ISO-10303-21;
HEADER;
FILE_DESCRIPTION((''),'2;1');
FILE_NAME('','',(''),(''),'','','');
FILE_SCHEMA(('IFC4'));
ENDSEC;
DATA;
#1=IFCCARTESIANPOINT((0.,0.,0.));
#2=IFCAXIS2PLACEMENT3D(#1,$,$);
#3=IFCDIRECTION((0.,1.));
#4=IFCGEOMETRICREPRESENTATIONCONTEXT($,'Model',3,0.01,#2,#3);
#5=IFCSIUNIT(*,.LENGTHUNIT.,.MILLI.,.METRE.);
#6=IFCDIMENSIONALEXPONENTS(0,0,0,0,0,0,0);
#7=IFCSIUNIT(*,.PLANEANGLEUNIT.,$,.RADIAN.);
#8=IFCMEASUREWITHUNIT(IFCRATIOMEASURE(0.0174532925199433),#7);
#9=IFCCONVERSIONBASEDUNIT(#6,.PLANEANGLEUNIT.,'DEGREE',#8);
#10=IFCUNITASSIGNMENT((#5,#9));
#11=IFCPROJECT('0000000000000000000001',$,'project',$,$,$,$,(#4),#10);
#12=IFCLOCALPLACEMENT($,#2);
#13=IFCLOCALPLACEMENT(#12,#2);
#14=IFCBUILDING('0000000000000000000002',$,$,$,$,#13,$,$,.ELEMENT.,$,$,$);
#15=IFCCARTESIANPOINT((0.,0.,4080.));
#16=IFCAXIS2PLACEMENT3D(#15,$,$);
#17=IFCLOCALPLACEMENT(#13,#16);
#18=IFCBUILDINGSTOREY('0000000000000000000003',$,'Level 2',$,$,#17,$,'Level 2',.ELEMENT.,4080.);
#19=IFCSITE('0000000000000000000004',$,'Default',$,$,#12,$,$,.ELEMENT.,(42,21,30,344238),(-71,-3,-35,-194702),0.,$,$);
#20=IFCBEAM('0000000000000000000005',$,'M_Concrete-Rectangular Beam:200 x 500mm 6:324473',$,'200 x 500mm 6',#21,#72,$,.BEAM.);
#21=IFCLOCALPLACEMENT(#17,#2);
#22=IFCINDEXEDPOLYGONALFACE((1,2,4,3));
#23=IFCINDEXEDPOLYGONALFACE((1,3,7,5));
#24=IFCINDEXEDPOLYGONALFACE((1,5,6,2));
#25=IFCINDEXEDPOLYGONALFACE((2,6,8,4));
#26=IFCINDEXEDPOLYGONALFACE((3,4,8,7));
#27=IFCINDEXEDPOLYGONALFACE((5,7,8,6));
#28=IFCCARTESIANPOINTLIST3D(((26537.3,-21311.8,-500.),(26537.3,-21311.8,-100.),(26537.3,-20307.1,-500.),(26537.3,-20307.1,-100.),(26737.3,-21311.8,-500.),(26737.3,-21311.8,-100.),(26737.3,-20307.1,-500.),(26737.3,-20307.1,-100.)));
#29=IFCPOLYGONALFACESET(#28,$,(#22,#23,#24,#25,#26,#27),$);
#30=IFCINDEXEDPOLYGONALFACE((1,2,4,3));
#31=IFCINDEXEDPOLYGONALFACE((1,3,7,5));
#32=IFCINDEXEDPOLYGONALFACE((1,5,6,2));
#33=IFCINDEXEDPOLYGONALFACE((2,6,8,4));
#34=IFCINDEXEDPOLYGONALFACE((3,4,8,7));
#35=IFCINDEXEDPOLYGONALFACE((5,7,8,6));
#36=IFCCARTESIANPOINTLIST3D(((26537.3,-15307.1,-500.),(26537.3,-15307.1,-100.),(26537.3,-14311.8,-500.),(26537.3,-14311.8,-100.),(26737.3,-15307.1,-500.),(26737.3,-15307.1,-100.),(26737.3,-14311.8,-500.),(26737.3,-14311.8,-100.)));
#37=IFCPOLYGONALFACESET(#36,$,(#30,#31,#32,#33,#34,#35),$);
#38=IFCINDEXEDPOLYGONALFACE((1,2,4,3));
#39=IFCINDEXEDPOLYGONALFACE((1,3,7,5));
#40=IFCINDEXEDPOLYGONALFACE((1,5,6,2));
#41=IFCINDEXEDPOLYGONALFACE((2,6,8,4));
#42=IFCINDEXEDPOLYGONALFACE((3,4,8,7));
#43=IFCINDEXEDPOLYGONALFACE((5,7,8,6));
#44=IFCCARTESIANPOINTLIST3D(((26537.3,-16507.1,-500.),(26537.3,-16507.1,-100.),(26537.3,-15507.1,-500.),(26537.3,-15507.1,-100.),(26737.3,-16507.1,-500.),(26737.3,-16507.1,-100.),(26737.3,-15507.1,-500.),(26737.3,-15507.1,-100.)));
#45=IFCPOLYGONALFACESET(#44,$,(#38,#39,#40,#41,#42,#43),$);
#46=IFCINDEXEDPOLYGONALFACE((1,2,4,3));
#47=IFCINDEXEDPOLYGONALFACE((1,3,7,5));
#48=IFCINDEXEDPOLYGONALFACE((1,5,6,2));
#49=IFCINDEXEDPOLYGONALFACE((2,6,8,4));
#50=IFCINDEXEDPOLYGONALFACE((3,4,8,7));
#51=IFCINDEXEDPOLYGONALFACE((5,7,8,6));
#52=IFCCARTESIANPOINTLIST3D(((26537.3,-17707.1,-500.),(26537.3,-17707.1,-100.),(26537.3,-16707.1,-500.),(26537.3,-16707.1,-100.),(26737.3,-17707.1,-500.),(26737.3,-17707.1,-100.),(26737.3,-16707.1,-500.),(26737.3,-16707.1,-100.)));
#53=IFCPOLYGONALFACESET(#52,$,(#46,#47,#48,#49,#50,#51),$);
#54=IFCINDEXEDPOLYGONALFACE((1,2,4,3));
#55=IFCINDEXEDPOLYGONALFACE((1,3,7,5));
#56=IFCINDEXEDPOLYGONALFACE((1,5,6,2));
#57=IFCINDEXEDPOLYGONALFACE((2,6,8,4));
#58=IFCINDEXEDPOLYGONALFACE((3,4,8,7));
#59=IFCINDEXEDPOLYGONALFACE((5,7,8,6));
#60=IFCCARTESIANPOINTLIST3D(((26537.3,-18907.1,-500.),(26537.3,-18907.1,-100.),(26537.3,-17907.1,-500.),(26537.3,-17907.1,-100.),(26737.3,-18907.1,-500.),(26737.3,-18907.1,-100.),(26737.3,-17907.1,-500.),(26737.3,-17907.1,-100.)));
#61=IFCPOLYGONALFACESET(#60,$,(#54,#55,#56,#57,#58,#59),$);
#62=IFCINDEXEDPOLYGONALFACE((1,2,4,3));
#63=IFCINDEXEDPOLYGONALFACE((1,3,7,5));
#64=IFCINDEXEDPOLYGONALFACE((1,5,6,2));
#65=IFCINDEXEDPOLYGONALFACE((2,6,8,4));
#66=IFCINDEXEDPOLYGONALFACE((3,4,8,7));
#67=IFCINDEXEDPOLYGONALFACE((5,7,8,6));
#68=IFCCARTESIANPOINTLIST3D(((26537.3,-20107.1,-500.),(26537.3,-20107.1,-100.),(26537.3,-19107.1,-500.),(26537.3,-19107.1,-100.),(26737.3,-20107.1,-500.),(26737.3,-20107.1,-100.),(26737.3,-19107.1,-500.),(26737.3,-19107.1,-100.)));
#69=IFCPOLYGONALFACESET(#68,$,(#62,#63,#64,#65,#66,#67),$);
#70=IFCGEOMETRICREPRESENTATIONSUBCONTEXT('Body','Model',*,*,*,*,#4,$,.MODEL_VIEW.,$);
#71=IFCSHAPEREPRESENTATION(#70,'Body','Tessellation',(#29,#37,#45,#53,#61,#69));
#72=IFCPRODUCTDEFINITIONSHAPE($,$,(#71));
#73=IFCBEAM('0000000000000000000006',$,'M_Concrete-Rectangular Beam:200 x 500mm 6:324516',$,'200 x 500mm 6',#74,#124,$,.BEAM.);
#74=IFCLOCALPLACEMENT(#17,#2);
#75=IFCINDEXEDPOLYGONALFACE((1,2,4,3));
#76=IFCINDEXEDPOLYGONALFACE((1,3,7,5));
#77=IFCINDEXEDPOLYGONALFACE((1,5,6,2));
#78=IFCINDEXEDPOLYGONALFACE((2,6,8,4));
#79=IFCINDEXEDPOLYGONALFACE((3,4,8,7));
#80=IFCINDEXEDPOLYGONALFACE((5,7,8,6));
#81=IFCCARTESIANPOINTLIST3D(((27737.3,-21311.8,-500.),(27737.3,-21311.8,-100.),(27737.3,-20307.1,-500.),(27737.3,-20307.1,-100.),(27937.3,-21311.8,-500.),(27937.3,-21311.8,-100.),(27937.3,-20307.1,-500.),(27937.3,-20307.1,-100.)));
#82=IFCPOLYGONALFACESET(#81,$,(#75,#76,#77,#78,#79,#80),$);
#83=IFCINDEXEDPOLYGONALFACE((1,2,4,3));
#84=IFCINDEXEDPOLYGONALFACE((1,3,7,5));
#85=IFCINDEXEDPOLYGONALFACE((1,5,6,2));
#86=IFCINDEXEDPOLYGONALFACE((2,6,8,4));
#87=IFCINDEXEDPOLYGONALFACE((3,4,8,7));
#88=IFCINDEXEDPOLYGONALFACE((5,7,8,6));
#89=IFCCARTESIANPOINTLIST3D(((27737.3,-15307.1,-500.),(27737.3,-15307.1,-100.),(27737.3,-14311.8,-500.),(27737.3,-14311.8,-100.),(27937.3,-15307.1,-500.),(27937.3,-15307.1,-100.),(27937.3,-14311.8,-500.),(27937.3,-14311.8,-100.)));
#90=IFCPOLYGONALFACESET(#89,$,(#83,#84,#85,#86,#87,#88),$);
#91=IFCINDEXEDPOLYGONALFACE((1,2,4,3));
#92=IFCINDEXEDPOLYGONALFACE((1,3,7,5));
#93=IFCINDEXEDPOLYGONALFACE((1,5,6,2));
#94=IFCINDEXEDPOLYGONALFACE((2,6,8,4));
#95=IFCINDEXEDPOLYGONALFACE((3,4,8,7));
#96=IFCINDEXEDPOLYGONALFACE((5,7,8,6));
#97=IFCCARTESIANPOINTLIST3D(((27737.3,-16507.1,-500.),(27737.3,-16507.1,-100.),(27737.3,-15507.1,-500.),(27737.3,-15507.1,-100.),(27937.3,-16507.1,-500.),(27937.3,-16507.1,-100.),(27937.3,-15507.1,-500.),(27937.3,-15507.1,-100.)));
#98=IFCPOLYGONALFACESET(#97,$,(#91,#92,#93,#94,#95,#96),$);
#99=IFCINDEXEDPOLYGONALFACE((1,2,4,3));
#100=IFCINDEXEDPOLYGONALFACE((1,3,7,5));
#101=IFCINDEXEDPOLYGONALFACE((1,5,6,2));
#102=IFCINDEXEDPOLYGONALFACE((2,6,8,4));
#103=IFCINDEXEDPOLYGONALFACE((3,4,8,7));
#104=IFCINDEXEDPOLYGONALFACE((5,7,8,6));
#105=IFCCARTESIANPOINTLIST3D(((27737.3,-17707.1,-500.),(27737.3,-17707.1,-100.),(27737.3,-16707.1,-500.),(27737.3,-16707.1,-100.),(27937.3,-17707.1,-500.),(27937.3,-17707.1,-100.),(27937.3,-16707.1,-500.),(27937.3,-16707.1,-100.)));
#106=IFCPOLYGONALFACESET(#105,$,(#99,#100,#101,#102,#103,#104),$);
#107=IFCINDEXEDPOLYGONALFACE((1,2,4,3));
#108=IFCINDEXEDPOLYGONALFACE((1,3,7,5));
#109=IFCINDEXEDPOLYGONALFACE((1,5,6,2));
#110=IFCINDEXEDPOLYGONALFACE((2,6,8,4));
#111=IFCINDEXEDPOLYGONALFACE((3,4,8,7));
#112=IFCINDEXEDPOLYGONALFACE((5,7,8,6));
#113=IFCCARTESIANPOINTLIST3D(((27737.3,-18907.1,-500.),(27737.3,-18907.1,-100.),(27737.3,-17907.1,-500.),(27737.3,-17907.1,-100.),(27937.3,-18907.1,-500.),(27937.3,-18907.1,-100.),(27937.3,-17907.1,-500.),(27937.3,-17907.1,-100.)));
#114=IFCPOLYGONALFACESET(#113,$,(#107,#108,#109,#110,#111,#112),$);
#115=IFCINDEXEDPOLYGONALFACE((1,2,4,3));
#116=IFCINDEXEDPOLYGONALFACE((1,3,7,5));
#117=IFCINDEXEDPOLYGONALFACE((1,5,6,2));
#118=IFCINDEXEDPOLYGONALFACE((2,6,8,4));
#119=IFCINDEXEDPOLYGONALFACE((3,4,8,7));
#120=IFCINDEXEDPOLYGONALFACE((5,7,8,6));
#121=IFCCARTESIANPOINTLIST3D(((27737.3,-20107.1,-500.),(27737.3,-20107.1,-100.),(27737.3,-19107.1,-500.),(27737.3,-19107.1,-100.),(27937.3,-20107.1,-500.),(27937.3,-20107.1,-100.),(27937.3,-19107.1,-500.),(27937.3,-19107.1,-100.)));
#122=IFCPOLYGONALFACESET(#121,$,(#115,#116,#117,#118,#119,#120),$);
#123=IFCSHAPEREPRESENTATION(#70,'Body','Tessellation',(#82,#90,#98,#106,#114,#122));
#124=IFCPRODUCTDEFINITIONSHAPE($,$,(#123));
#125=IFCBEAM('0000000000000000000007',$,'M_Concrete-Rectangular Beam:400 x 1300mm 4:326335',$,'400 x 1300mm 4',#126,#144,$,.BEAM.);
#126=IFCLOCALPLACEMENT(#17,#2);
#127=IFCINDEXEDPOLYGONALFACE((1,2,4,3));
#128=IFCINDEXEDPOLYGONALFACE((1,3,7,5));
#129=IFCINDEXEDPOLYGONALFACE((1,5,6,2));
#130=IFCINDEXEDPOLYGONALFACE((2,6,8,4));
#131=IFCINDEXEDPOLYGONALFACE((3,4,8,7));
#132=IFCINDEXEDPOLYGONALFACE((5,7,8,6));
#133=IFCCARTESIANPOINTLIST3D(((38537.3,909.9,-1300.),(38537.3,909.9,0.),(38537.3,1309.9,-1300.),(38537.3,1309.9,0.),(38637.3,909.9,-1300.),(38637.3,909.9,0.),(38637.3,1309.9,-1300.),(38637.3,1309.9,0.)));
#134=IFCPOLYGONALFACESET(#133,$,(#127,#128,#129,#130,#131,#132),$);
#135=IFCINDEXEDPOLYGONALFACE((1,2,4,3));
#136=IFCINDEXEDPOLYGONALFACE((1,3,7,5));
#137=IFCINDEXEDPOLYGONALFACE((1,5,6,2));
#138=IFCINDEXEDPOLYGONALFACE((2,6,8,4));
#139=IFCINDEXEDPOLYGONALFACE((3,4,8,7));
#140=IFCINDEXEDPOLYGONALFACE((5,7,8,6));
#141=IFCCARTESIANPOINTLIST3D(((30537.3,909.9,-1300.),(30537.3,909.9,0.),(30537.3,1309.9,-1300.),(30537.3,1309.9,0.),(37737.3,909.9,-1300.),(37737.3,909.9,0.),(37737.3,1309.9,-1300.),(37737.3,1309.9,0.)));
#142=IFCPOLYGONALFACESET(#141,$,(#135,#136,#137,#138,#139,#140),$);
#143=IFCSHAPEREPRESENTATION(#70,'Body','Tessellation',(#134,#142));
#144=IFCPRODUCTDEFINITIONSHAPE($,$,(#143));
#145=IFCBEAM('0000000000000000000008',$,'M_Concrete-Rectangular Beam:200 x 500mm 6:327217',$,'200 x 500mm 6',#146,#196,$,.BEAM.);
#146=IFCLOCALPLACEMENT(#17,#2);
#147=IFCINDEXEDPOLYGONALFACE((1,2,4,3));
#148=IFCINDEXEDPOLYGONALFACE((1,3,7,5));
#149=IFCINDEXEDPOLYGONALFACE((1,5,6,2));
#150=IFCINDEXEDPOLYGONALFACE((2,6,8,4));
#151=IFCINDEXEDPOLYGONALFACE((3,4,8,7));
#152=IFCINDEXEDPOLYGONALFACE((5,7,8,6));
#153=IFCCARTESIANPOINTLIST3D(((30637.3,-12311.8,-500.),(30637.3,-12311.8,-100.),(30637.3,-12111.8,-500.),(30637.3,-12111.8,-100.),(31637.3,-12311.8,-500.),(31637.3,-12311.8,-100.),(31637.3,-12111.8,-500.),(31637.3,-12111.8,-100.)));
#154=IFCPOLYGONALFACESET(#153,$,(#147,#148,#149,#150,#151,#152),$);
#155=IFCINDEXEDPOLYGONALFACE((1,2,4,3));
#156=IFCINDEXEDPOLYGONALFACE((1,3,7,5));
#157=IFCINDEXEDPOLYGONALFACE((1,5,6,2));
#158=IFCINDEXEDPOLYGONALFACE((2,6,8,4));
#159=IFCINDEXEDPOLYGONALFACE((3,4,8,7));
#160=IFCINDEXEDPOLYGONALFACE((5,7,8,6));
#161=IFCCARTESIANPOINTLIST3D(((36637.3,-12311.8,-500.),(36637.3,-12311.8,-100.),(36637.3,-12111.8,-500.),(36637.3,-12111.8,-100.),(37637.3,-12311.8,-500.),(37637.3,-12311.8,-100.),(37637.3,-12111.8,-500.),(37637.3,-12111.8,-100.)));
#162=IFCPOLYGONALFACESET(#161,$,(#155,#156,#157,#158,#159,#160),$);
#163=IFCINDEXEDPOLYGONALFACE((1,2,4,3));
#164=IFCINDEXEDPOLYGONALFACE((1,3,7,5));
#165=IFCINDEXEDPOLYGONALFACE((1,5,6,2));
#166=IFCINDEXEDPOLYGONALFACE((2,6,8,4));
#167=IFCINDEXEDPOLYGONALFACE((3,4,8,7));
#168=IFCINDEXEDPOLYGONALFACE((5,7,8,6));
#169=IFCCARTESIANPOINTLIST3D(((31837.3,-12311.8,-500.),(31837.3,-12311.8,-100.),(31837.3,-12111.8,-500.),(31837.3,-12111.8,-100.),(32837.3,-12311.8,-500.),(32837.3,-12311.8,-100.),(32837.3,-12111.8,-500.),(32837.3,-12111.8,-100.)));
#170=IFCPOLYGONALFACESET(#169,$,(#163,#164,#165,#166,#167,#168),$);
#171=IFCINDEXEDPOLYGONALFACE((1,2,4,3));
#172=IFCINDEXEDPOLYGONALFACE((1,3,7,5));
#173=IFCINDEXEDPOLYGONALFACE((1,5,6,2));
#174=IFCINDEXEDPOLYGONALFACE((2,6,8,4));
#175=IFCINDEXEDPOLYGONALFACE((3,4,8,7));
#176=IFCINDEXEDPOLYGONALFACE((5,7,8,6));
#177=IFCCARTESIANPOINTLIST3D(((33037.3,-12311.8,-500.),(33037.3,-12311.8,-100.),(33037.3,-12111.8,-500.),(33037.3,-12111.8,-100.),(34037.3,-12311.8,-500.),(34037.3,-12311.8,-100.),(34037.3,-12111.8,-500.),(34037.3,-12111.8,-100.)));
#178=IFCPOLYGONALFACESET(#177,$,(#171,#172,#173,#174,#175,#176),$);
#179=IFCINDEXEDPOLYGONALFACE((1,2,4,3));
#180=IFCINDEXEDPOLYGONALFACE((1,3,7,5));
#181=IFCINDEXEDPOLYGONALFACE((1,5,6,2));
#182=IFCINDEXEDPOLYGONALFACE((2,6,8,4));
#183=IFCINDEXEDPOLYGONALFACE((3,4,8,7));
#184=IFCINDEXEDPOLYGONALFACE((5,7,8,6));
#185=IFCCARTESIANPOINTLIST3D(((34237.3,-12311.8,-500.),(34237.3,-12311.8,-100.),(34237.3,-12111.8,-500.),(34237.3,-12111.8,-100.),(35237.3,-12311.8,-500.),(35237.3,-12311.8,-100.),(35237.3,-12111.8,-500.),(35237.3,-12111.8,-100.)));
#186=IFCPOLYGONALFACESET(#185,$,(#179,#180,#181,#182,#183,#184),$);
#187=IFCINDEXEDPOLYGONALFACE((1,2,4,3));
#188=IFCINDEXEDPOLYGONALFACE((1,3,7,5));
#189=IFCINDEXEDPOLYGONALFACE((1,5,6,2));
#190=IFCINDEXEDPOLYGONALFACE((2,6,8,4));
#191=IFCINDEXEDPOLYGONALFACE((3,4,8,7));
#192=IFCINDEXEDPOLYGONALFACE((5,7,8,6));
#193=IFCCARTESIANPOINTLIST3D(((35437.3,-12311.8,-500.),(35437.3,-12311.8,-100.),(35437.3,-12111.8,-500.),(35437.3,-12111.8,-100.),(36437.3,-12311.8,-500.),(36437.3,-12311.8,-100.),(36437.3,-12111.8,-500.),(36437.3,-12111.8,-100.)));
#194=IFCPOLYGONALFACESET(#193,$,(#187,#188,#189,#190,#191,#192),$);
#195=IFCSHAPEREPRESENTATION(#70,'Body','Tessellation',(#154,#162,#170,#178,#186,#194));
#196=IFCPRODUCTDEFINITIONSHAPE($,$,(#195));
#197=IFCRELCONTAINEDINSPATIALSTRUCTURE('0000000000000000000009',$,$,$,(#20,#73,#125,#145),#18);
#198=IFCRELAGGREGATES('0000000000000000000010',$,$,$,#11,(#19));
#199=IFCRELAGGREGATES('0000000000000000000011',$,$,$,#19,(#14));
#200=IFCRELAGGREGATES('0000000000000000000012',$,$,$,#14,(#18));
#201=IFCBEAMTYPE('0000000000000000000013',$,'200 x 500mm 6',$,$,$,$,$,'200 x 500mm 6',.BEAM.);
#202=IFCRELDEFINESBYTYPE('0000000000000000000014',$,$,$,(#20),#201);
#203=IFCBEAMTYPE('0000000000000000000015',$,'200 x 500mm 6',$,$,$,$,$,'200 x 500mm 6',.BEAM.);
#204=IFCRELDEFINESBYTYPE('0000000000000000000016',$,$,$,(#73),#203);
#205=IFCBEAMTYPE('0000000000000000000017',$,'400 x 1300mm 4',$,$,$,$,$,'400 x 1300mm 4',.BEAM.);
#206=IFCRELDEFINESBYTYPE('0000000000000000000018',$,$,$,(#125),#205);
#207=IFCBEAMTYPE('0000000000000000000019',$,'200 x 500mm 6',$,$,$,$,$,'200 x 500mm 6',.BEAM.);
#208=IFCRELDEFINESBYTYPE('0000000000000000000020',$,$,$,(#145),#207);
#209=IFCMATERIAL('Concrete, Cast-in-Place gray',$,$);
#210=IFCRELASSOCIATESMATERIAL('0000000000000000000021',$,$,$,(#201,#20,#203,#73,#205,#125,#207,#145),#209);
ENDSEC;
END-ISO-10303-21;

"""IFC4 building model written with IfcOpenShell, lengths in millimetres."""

from ifc_helpers import new_model, entity, si_unit, converted_unit, direction, frame, frame_2d, origin, origin_2d_with_axis, place, context, subcontext, project, spatial, rectangle, extrude, source, transform, mapped, material, type_object, type_shapes, element, save


model = new_model("IFC4")

# Units and contexts
model_context = context("Model", 3, precision=0.01, world=origin(), true_north=direction((0.0, 1.0)))
body_context = subcontext(model_context, "Body", "Model", "MODEL_VIEW")
ifc_project = project(units=[si_unit("LENGTHUNIT", "METRE", prefix="MILLI"), converted_unit("PLANEANGLEUNIT", "DEGREE", entity("IfcRatioMeasure", 0.0174532925199433), si_unit("PLANEANGLEUNIT", "RADIAN"), dimensions=[0, 0, 0, 0, 0, 0, 0])], contexts=[model_context])

# Site, building, storey
site_placement = place(None, origin())
site = spatial("IfcSite", under=ifc_project, at=site_placement, Name="Default", CompositionType="ELEMENT", RefLatitude=(42, 21, 30, 344238), RefLongitude=(-71, -3, -35, -194702), RefElevation=0.0)
building_placement = place(site_placement, origin())
building = spatial("IfcBuilding", under=site, at=building_placement, CompositionType="ELEMENT")
storey_placement = place(building_placement, frame((0.0, 0.0, 4080.0)))
storey = spatial("IfcBuildingStorey", under=building, at=storey_placement, Name="Level 2", LongName="Level 2", CompositionType="ELEMENT", Elevation=4080.0)

# Beams
ifc_material = material(Name="Concrete, Cast-in-Place gray")
beam_type_1 = type_object("IfcBeamType", Name="200 x 500mm 6", ElementType="200 x 500mm 6", PredefinedType="BEAM", material=ifc_material)
shared_shape_1 = source(origin(), body_context, "Body", "SweptSolid", [
    extrude(rectangle(XDim=1004.7, YDim=200.0, at=frame_2d((0.0, 0.0), x_axis=(1.0, 0.0))), frame((26637.3, -20809.5, 3580.0), z_axis=(0.0, 0.0, 1.0), x_axis=(0.0, 1.0, 0.0)), (0.0, 0.0, 1.0), 400.0),
    extrude(rectangle(XDim=995.3, YDim=200.0, at=frame_2d((0.0, 0.0), x_axis=(1.0, 0.0))), frame((26637.3, -14809.5, 3580.0), z_axis=(0.0, 0.0, 1.0), x_axis=(0.0, -1.0, 0.0)), (0.0, 0.0, 1.0), 400.0),
    extrude(rectangle(XDim=1000.0, YDim=200.0, at=origin_2d_with_axis()), frame((26637.3, -16007.1, 3580.0), z_axis=(0.0, 0.0, 1.0), x_axis=(0.0, -1.0, 0.0)), (0.0, 0.0, 1.0), 400.0),
    extrude(rectangle(XDim=1000.0, YDim=200.0, at=frame_2d((0.0, 0.0), x_axis=(1.0, 0.0))), frame((26637.3, -17207.1, 3580.0), z_axis=(0.0, 0.0, 1.0), x_axis=(0.0, -1.0, 0.0)), (0.0, 0.0, 1.0), 400.0),
    extrude(rectangle(XDim=1000.0, YDim=200.0, at=origin_2d_with_axis()), frame((26637.3, -18407.1, 3580.0), z_axis=(0.0, 0.0, 1.0), x_axis=(0.0, -1.0, 0.0)), (0.0, 0.0, 1.0), 400.0),
    extrude(rectangle(XDim=1000.0, YDim=200.0, at=frame_2d((0.0, 0.0), x_axis=(1.0, 0.0))), frame((26637.3, -19607.1, 3580.0), z_axis=(0.0, 0.0, 1.0), x_axis=(0.0, -1.0, 0.0)), (0.0, 0.0, 1.0), 400.0),
])
type_shapes(beam_type_1, [shared_shape_1])
beam_1_placement = place(storey_placement, frame((0.0, 0.0, -4080.0)))
element("IfcBeam", 1, at=beam_1_placement, inside=storey, type_object=beam_type_1, material=ifc_material, Name="M_Concrete-Rectangular Beam:200 x 500mm 6:324473", ObjectType="200 x 500mm 6", PredefinedType="BEAM", context=body_context, shape_type="MappedRepresentation", body=[
    mapped(shared_shape_1, transform((0.0, 0.0, 0.0), scale=1.0)),
])
beam_type_2 = type_object("IfcBeamType", Name="200 x 500mm 6", ElementType="200 x 500mm 6", PredefinedType="BEAM", material=ifc_material)
shared_shape_2 = source(origin(), body_context, "Body", "SweptSolid", [
    extrude(rectangle(XDim=1004.7, YDim=200.0, at=frame_2d((0.0, 0.0), x_axis=(1.0, 0.0))), frame((27837.3, -20809.5, 3580.0), z_axis=(0.0, 0.0, 1.0), x_axis=(0.0, 1.0, 0.0)), (0.0, 0.0, 1.0), 400.0),
    extrude(rectangle(XDim=995.3, YDim=200.0, at=frame_2d((0.0, 0.0), x_axis=(1.0, 0.0))), frame((27837.3, -14809.5, 3580.0), z_axis=(0.0, 0.0, 1.0), x_axis=(0.0, -1.0, 0.0)), (0.0, 0.0, 1.0), 400.0),
    extrude(rectangle(XDim=1000.0, YDim=200.0, at=origin_2d_with_axis()), frame((27837.3, -16007.1, 3580.0), z_axis=(0.0, 0.0, 1.0), x_axis=(0.0, -1.0, 0.0)), (0.0, 0.0, 1.0), 400.0),
    extrude(rectangle(XDim=1000.0, YDim=200.0, at=origin_2d_with_axis()), frame((27837.3, -17207.1, 3580.0), z_axis=(0.0, 0.0, 1.0), x_axis=(0.0, -1.0, 0.0)), (0.0, 0.0, 1.0), 400.0),
    extrude(rectangle(XDim=1000.0, YDim=200.0, at=frame_2d((0.0, 0.0), x_axis=(1.0, 0.0))), frame((27837.3, -18407.1, 3580.0), z_axis=(0.0, 0.0, 1.0), x_axis=(0.0, -1.0, 0.0)), (0.0, 0.0, 1.0), 400.0),
    extrude(rectangle(XDim=1000.0, YDim=200.0, at=frame_2d((0.0, 0.0), x_axis=(1.0, 0.0))), frame((27837.3, -19607.1, 3580.0), z_axis=(0.0, 0.0, 1.0), x_axis=(0.0, -1.0, 0.0)), (0.0, 0.0, 1.0), 400.0),
])
type_shapes(beam_type_2, [shared_shape_2])
beam_2_placement = place(storey_placement, frame((0.0, 0.0, -4080.0)))
element("IfcBeam", 2, at=beam_2_placement, inside=storey, type_object=beam_type_2, material=ifc_material, Name="M_Concrete-Rectangular Beam:200 x 500mm 6:324516", ObjectType="200 x 500mm 6", PredefinedType="BEAM", context=body_context, shape_type="MappedRepresentation", body=[
    mapped(shared_shape_2, transform((0.0, 0.0, 0.0), scale=1.0)),
])
beam_type_3 = type_object("IfcBeamType", Name="400 x 1300mm 4", ElementType="400 x 1300mm 4", PredefinedType="BEAM", material=ifc_material)
shared_shape_3 = source(origin(), body_context, "Body", "SweptSolid", [
    extrude(rectangle(XDim=100.0, YDim=400.0, at=frame_2d((0.0, 0.0), x_axis=(1.0, 0.0))), frame((38587.3, 1109.9, 2780.0), z_axis=(0.0, 0.0, 1.0), x_axis=(-1.0, 0.0, 0.0)), (0.0, 0.0, 1.0), 1300.0),
    extrude(rectangle(XDim=7200.0, YDim=400.0, at=frame_2d((0.0, 0.0), x_axis=(1.0, 0.0))), frame((34137.3, 1109.9, 2780.0), z_axis=(0.0, 0.0, 1.0), x_axis=(-1.0, 0.0, 0.0)), (0.0, 0.0, 1.0), 1300.0),
])
type_shapes(beam_type_3, [shared_shape_3])
beam_3_placement = place(storey_placement, frame((0.0, 0.0, -4080.0)))
element("IfcBeam", 3, at=beam_3_placement, inside=storey, type_object=beam_type_3, material=ifc_material, Name="M_Concrete-Rectangular Beam:400 x 1300mm 4:326335", ObjectType="400 x 1300mm 4", PredefinedType="BEAM", context=body_context, shape_type="MappedRepresentation", body=[
    mapped(shared_shape_3, transform((0.0, 0.0, 0.0), scale=1.0)),
])
beam_type_4 = type_object("IfcBeamType", Name="200 x 500mm 6", ElementType="200 x 500mm 6", PredefinedType="BEAM", material=ifc_material)
shared_shape_4 = source(origin(), body_context, "Body", "SweptSolid", [
    extrude(rectangle(XDim=1000.0, YDim=200.0, at=frame_2d((0.0, 0.0), x_axis=(1.0, 0.0))), frame((31137.3, -12211.8, 3580.0)), (0.0, 0.0, 1.0), 400.0),
    extrude(rectangle(XDim=1000.0, YDim=200.0, at=frame_2d((0.0, 0.0), x_axis=(1.0, 0.0))), frame((37137.3, -12211.8, 3580.0), z_axis=(0.0, 0.0, 1.0), x_axis=(-1.0, 0.0, 0.0)), (0.0, 0.0, 1.0), 400.0),
    extrude(rectangle(XDim=1000.0, YDim=200.0, at=frame_2d((0.0, 0.0), x_axis=(1.0, 0.0))), frame((32337.3, -12211.8, 3580.0)), (0.0, 0.0, 1.0), 400.0),
    extrude(rectangle(XDim=1000.0, YDim=200.0, at=frame_2d((0.0, 0.0), x_axis=(1.0, 0.0))), frame((33537.3, -12211.8, 3580.0)), (0.0, 0.0, 1.0), 400.0),
    extrude(rectangle(XDim=1000.0, YDim=200.0, at=frame_2d((0.0, 0.0), x_axis=(1.0, 0.0))), frame((34737.3, -12211.8, 3580.0)), (0.0, 0.0, 1.0), 400.0),
    extrude(rectangle(XDim=1000.0, YDim=200.0, at=origin_2d_with_axis()), frame((35937.3, -12211.8, 3580.0)), (0.0, 0.0, 1.0), 400.0),
])
type_shapes(beam_type_4, [shared_shape_4])
beam_4_placement = place(storey_placement, frame((0.0, 0.0, -4080.0)))
element("IfcBeam", 4, at=beam_4_placement, inside=storey, type_object=beam_type_4, material=ifc_material, Name="M_Concrete-Rectangular Beam:200 x 500mm 6:327217", ObjectType="200 x 500mm 6", PredefinedType="BEAM", context=body_context, shape_type="MappedRepresentation", body=[
    mapped(shared_shape_4, transform((0.0, 0.0, 0.0), scale=1.0)),
])

save(model, "model.ifc")
